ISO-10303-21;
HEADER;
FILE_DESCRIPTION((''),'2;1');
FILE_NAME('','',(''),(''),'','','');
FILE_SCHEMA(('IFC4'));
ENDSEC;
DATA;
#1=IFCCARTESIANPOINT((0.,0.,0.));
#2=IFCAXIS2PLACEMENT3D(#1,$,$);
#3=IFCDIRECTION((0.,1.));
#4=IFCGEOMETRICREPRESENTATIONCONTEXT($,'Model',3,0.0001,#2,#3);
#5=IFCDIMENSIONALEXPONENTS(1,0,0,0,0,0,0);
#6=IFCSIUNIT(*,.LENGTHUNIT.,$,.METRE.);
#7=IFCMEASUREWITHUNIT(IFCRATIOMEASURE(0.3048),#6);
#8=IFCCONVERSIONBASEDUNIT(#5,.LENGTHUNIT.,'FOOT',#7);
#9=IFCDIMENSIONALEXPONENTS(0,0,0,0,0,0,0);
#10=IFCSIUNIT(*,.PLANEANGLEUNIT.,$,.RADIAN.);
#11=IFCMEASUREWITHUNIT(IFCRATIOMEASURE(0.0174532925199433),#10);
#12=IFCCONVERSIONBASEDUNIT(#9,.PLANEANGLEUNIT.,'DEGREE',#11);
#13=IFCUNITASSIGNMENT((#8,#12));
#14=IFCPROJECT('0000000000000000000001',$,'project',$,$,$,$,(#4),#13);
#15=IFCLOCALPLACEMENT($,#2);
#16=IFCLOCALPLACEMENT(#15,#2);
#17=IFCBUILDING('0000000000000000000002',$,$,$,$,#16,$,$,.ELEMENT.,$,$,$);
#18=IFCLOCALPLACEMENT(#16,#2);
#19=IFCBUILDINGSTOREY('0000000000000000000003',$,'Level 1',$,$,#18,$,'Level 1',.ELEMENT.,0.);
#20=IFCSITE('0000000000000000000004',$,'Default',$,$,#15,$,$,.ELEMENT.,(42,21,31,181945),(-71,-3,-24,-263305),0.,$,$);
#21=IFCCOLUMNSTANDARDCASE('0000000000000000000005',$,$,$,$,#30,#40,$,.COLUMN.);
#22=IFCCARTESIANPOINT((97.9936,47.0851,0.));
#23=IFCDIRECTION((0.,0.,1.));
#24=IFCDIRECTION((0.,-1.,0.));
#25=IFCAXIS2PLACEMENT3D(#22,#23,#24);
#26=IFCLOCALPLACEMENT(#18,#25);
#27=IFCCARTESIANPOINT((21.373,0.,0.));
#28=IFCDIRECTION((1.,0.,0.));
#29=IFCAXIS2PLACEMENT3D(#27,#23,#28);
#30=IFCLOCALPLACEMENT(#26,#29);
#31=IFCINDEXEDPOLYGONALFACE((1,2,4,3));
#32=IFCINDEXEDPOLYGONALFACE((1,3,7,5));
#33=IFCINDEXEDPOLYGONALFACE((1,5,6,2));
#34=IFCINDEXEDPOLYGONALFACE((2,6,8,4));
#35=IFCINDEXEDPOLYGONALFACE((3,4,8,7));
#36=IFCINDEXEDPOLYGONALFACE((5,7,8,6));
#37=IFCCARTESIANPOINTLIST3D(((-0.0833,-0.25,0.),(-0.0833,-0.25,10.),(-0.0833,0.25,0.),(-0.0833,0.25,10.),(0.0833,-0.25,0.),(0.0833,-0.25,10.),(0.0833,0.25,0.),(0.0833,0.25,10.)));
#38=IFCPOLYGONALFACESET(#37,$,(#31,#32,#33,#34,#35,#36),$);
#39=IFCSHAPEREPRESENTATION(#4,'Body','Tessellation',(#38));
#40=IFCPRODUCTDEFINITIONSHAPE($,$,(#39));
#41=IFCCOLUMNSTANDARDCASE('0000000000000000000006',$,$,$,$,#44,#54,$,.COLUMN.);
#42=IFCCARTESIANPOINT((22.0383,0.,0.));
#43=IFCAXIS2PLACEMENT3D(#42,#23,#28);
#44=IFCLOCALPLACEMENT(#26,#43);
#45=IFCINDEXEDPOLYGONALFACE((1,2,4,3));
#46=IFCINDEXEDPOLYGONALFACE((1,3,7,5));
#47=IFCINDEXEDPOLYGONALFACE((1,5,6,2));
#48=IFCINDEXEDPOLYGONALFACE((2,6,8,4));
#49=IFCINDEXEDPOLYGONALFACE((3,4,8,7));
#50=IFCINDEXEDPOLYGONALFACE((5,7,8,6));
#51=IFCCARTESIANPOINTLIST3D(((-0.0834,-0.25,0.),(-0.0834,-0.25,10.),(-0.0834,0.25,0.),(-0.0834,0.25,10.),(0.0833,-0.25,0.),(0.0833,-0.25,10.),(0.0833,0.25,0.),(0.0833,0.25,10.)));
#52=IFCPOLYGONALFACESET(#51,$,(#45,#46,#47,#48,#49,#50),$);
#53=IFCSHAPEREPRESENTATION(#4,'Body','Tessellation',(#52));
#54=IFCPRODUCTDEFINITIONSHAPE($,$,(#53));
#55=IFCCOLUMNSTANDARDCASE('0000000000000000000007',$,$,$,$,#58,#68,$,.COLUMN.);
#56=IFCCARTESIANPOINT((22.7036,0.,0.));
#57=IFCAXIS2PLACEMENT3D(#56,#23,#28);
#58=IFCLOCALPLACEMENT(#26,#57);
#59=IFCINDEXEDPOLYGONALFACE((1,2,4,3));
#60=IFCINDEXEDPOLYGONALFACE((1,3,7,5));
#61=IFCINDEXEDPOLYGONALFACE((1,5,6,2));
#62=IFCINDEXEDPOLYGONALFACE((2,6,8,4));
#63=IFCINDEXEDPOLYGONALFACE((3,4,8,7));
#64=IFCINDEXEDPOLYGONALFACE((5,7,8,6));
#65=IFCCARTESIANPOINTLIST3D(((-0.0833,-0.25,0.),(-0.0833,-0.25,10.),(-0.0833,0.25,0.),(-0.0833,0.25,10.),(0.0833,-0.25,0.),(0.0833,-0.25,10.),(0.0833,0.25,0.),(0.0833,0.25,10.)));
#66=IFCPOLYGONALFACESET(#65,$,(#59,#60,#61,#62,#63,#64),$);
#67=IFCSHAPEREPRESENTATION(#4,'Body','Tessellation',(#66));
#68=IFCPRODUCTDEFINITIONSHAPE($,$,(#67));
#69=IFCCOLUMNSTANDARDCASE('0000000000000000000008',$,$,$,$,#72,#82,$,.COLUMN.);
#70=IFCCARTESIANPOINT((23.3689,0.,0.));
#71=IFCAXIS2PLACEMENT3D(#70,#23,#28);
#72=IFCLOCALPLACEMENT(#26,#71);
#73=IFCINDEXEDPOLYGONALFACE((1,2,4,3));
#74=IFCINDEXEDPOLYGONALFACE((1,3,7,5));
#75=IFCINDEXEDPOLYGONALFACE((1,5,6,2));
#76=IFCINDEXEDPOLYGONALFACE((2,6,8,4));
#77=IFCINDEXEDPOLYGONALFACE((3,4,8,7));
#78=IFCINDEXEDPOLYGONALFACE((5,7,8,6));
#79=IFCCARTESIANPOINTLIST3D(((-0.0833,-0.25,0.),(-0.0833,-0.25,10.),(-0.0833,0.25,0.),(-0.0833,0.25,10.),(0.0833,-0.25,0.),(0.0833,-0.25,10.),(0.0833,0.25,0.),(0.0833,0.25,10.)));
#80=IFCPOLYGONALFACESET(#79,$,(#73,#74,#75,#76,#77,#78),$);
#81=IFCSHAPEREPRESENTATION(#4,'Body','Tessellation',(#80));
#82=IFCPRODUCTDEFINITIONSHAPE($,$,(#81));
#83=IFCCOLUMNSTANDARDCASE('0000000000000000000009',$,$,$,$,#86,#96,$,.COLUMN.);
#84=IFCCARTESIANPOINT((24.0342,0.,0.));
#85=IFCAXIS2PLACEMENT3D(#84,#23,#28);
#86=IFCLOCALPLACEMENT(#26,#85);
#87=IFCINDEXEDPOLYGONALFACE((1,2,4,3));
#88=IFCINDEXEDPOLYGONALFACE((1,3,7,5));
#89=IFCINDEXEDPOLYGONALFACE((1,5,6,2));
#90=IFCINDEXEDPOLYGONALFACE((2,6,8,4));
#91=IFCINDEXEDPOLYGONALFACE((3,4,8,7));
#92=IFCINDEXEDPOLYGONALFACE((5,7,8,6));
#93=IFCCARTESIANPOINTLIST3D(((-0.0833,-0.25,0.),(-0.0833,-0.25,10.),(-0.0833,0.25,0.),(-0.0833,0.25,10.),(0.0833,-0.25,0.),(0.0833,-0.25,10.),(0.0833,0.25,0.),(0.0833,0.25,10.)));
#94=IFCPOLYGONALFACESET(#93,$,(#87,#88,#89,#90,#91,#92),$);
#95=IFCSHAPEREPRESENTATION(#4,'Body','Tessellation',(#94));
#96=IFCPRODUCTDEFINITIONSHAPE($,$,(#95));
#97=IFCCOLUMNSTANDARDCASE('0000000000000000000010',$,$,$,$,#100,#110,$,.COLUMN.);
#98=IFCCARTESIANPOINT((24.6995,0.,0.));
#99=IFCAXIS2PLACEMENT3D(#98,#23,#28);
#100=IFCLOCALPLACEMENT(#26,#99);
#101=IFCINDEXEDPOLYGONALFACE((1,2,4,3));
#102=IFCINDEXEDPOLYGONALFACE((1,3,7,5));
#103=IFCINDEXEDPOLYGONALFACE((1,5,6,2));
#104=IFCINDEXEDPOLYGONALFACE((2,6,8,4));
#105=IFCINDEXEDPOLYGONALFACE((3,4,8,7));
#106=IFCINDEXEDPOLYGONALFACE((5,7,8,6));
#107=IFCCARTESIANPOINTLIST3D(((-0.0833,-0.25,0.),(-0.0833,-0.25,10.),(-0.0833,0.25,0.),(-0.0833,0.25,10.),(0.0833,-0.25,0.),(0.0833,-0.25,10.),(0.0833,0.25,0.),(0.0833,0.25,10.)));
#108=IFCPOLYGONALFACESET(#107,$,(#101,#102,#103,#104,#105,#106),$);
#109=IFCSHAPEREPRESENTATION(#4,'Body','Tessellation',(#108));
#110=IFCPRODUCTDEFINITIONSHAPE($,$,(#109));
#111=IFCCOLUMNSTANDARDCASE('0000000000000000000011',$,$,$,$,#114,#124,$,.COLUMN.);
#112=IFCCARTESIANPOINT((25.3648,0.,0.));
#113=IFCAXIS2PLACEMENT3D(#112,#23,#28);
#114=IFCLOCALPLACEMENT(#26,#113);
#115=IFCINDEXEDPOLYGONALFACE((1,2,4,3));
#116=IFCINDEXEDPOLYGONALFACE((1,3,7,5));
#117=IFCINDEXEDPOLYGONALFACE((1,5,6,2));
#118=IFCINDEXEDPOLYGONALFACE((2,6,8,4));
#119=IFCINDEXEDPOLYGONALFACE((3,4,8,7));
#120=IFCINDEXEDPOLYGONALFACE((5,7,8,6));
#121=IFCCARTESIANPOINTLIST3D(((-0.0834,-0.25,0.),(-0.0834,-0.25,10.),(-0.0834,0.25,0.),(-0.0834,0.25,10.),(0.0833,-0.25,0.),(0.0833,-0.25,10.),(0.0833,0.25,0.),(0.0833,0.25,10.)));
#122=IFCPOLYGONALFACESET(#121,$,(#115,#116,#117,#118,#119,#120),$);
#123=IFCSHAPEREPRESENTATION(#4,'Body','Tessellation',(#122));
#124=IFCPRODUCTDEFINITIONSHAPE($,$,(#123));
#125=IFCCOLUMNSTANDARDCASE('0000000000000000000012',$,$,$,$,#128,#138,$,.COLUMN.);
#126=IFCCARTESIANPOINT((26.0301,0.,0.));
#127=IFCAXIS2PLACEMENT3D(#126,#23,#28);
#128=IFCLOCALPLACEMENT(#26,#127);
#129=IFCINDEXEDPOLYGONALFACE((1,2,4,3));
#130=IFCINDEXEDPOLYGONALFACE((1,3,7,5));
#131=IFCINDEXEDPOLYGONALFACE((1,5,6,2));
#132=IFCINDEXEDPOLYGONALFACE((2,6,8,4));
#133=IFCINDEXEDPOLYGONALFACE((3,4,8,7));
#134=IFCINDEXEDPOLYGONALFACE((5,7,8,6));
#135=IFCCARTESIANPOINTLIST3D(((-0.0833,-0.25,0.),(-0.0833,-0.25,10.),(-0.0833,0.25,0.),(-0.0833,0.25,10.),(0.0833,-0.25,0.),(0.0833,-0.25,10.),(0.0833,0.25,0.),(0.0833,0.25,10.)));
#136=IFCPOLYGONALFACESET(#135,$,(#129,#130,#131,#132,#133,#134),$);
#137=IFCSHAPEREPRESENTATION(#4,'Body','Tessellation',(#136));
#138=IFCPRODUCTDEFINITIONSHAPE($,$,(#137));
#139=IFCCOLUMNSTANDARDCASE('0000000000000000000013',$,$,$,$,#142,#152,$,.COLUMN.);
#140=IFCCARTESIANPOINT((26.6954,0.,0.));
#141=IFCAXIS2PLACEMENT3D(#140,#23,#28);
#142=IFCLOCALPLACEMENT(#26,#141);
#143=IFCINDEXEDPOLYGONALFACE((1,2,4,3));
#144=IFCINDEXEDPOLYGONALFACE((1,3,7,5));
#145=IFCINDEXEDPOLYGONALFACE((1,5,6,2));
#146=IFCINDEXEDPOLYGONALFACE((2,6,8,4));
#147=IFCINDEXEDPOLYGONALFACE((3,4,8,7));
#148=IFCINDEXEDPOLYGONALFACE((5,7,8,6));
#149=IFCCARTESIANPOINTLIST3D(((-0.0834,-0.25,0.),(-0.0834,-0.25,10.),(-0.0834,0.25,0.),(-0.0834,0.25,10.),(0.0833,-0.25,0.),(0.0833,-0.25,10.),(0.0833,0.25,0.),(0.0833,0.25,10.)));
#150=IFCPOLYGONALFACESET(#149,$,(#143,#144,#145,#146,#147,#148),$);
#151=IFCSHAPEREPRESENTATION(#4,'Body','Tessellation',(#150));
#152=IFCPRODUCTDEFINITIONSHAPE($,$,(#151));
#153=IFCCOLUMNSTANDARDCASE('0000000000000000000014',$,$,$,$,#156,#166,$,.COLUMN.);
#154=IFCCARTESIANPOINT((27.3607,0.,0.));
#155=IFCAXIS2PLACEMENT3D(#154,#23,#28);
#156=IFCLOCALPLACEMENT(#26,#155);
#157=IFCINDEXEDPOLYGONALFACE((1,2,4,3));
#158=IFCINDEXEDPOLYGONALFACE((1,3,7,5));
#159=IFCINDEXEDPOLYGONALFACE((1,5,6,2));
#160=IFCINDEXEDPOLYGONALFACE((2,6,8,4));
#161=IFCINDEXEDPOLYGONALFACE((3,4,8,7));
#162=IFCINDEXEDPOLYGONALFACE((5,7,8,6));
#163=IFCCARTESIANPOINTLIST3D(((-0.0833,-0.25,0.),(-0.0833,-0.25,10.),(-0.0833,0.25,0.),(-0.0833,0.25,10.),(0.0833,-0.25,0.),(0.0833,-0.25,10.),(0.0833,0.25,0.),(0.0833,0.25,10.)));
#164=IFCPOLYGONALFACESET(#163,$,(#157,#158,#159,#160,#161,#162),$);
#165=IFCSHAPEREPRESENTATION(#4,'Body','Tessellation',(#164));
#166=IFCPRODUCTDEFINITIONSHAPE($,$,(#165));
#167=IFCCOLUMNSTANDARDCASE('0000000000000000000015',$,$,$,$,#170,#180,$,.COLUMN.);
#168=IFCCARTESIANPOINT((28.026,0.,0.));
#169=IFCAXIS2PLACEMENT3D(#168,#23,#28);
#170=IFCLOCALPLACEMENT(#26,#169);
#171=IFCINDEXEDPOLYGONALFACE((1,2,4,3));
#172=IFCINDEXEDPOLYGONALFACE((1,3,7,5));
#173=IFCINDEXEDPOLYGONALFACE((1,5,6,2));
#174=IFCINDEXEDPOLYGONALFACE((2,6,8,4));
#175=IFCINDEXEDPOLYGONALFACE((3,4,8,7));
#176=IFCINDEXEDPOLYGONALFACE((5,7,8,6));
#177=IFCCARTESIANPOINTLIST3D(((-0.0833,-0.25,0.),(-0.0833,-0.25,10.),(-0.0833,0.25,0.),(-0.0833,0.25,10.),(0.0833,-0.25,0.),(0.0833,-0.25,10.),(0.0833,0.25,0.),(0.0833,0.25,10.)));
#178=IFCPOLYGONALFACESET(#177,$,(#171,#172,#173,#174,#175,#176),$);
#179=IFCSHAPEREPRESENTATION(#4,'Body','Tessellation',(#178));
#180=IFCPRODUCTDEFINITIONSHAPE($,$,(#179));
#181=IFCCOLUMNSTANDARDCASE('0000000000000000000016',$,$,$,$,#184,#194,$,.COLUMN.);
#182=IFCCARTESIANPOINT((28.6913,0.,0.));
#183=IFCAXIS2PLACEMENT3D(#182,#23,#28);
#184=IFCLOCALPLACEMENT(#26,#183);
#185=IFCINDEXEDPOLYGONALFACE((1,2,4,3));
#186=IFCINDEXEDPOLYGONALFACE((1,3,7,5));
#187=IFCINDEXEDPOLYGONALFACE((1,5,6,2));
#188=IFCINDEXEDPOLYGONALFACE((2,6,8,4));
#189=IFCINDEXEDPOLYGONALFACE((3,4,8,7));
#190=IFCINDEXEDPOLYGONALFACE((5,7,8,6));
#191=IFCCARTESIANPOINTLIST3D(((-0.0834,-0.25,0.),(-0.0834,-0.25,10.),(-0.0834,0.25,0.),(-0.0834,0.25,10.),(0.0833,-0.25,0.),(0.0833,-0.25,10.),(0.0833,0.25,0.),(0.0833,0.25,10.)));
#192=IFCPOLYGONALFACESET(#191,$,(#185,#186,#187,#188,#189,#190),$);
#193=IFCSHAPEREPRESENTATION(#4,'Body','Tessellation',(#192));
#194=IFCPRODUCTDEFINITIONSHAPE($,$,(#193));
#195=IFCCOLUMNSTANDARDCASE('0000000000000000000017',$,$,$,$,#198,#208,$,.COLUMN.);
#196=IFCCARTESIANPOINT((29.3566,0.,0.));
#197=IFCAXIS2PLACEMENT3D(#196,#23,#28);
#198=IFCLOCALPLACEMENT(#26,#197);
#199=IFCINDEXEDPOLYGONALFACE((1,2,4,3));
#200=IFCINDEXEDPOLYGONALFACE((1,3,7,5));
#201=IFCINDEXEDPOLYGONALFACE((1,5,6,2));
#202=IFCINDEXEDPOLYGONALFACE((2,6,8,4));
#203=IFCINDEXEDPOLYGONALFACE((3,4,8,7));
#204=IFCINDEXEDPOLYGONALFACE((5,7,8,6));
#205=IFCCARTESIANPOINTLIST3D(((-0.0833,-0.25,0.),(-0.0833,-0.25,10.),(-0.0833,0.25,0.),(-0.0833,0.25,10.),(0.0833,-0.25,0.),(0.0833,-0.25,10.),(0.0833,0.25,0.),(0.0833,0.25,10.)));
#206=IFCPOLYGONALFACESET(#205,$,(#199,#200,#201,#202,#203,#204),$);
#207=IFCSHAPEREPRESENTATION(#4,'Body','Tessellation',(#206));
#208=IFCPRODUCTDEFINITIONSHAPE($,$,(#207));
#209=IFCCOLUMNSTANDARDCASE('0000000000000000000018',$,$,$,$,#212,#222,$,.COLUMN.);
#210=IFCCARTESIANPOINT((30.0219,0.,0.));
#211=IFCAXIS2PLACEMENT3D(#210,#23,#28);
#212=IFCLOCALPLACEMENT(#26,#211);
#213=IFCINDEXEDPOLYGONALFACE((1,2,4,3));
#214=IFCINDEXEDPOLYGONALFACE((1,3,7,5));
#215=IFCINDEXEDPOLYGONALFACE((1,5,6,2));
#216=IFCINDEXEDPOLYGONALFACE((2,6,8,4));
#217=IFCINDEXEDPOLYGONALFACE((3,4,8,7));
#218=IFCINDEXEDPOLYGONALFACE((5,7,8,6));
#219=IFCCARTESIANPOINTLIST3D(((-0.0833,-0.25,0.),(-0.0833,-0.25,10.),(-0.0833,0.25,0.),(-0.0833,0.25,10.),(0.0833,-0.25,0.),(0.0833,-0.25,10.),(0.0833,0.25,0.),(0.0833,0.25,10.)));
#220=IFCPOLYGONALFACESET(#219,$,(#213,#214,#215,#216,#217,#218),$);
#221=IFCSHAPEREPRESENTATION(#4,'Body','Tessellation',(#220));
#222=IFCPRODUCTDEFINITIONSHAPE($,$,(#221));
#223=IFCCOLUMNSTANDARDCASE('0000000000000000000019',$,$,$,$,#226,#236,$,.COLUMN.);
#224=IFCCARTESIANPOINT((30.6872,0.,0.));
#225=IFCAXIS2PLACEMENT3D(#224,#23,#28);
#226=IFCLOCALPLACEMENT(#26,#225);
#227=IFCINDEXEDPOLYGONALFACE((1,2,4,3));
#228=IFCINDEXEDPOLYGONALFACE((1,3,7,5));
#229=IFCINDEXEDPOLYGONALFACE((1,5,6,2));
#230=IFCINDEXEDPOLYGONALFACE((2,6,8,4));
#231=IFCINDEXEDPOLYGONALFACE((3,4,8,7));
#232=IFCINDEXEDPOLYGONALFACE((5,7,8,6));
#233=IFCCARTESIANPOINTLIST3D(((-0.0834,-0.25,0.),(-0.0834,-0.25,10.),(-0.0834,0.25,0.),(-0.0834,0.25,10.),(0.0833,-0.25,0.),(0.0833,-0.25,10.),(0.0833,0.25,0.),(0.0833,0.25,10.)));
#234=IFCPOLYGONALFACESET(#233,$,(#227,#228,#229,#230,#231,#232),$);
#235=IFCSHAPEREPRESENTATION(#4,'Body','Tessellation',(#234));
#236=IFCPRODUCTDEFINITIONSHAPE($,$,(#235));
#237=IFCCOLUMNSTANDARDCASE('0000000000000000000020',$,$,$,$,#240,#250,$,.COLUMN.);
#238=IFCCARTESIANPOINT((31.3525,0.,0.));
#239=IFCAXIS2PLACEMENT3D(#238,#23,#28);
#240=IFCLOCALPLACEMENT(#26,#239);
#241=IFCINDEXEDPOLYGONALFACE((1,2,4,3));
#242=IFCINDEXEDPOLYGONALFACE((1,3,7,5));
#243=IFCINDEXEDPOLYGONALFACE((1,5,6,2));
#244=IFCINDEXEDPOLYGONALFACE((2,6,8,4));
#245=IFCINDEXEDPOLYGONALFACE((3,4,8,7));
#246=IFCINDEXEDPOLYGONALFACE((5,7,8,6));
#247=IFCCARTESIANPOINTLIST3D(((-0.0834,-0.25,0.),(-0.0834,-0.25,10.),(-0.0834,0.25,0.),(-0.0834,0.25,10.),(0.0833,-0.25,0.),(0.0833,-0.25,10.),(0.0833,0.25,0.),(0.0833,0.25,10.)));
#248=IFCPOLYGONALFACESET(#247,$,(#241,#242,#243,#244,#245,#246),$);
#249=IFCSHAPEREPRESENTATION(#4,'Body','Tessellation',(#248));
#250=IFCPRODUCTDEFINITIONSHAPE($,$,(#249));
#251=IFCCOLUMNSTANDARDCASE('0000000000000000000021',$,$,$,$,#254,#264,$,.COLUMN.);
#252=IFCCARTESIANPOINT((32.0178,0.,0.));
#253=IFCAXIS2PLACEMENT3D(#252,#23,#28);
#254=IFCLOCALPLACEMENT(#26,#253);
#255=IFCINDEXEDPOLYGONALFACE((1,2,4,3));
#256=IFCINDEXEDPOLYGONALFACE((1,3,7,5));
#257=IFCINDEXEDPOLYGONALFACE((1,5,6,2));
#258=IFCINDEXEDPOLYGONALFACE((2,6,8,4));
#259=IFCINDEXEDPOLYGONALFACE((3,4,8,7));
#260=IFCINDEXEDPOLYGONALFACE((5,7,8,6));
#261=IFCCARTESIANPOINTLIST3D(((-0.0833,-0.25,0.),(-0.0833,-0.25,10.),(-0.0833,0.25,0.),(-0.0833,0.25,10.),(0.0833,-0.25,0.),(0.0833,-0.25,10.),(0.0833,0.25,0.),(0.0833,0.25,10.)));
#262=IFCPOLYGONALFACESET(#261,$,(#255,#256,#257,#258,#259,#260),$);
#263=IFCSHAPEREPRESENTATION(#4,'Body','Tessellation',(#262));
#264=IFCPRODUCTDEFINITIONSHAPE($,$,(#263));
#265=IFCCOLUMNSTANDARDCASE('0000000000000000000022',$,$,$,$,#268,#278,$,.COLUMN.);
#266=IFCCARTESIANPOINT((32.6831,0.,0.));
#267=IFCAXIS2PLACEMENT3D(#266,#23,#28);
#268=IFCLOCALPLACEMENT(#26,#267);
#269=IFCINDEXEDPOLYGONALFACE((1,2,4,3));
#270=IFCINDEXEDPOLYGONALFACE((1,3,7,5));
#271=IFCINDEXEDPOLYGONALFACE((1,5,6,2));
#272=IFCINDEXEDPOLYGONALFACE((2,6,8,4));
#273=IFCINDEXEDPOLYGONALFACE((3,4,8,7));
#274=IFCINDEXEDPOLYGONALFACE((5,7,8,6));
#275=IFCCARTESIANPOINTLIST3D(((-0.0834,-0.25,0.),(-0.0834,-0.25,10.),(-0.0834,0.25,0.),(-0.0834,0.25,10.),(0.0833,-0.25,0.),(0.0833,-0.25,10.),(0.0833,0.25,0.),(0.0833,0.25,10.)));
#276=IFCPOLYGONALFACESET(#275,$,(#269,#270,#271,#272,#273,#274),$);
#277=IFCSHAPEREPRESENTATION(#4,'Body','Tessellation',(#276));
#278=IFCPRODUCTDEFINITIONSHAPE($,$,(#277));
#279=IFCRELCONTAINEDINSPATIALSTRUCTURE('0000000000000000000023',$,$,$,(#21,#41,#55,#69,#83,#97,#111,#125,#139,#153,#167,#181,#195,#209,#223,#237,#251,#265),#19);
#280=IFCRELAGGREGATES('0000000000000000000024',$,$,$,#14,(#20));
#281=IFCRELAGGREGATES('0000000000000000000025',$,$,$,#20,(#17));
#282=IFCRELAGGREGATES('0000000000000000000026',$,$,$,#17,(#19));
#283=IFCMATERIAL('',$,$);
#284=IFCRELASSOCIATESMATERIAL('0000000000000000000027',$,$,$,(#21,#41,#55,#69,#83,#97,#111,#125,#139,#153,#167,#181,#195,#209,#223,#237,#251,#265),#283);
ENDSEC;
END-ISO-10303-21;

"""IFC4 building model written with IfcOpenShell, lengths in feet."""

from ifc_helpers import new_model, entity, si_unit, converted_unit, direction, frame, origin, place, context, project, spatial, rectangle, extrude, material, element, save


model = new_model("IFC4")

# Units and contexts
model_context = context("Model", 3, precision=0.0001, world=origin(), true_north=direction((0.0, 1.0)))
ifc_project = project(units=[converted_unit("LENGTHUNIT", "FOOT", entity("IfcRatioMeasure", 0.3048), si_unit("LENGTHUNIT", "METRE"), dimensions=[1, 0, 0, 0, 0, 0, 0]), converted_unit("PLANEANGLEUNIT", "DEGREE", entity("IfcRatioMeasure", 0.0174532925199433), si_unit("PLANEANGLEUNIT", "RADIAN"), dimensions=[0, 0, 0, 0, 0, 0, 0])], contexts=[model_context])

# Site, building, storey
site_placement = place(None, origin())
site = spatial("IfcSite", under=ifc_project, at=site_placement, Name="Default", CompositionType="ELEMENT", RefLatitude=(42, 21, 31, 181945), RefLongitude=(-71, -3, -24, -263305), RefElevation=0.0)
building_placement = place(site_placement, origin())
building = spatial("IfcBuilding", under=site, at=building_placement, CompositionType="ELEMENT")
storey_placement = place(building_placement, origin())
storey = spatial("IfcBuildingStorey", under=building, at=storey_placement, Name="Level 1", LongName="Level 1", CompositionType="ELEMENT", Elevation=0.0)

# Columns
ifc_material = material(Name="")
placement = place(storey_placement, frame((97.9936, 47.0851, 0.0), z_axis=(0.0, 0.0, 1.0), x_axis=(0.0, -1.0, 0.0)))
for number, where, z_axis, x_axis in (
    (1, (21.373, 0.0, 0.0), (0.0, 0.0, 1.0), (1.0, 0.0, 0.0)),
    (2, (22.0383, 0.0, 0.0), (0.0, 0.0, 1.0), (1.0, 0.0, 0.0)),
    (3, (22.7036, 0.0, 0.0), (0.0, 0.0, 1.0), (1.0, 0.0, 0.0)),
    (4, (23.3689, 0.0, 0.0), (0.0, 0.0, 1.0), (1.0, 0.0, 0.0)),
    (5, (24.0342, 0.0, 0.0), (0.0, 0.0, 1.0), (1.0, 0.0, 0.0)),
    (6, (24.6995, 0.0, 0.0), (0.0, 0.0, 1.0), (1.0, 0.0, 0.0)),
    (7, (25.3648, 0.0, 0.0), (0.0, 0.0, 1.0), (1.0, 0.0, 0.0)),
    (8, (26.0301, 0.0, 0.0), (0.0, 0.0, 1.0), (1.0, 0.0, 0.0)),
    (9, (26.6954, 0.0, 0.0), (0.0, 0.0, 1.0), (1.0, 0.0, 0.0)),
    (10, (27.3607, 0.0, 0.0), (0.0, 0.0, 1.0), (1.0, 0.0, 0.0)),
    (11, (28.026, 0.0, 0.0), (0.0, 0.0, 1.0), (1.0, 0.0, 0.0)),
    (12, (28.6913, 0.0, 0.0), (0.0, 0.0, 1.0), (1.0, 0.0, 0.0)),
    (13, (29.3566, 0.0, 0.0), (0.0, 0.0, 1.0), (1.0, 0.0, 0.0)),
    (14, (30.0219, 0.0, 0.0), (0.0, 0.0, 1.0), (1.0, 0.0, 0.0)),
    (15, (30.6872, 0.0, 0.0), (0.0, 0.0, 1.0), (1.0, 0.0, 0.0)),
    (16, (31.3525, 0.0, 0.0), (0.0, 0.0, 1.0), (1.0, 0.0, 0.0)),
    (17, (32.0178, 0.0, 0.0), (0.0, 0.0, 1.0), (1.0, 0.0, 0.0)),
    (18, (32.6831, 0.0, 0.0), (0.0, 0.0, 1.0), (1.0, 0.0, 0.0)),
):
    element("IfcColumnStandardCase", number, at=place(placement, frame(where, z_axis=z_axis, x_axis=x_axis)), inside=storey, material=ifc_material, PredefinedType="COLUMN", context=model_context, shape_type="SweptSolid", body=[
        extrude(rectangle(XDim=0.1667, YDim=0.5), origin(), (0.0, 0.0, 1.0), 10.0),
    ])

save(model, "model.ifc")
